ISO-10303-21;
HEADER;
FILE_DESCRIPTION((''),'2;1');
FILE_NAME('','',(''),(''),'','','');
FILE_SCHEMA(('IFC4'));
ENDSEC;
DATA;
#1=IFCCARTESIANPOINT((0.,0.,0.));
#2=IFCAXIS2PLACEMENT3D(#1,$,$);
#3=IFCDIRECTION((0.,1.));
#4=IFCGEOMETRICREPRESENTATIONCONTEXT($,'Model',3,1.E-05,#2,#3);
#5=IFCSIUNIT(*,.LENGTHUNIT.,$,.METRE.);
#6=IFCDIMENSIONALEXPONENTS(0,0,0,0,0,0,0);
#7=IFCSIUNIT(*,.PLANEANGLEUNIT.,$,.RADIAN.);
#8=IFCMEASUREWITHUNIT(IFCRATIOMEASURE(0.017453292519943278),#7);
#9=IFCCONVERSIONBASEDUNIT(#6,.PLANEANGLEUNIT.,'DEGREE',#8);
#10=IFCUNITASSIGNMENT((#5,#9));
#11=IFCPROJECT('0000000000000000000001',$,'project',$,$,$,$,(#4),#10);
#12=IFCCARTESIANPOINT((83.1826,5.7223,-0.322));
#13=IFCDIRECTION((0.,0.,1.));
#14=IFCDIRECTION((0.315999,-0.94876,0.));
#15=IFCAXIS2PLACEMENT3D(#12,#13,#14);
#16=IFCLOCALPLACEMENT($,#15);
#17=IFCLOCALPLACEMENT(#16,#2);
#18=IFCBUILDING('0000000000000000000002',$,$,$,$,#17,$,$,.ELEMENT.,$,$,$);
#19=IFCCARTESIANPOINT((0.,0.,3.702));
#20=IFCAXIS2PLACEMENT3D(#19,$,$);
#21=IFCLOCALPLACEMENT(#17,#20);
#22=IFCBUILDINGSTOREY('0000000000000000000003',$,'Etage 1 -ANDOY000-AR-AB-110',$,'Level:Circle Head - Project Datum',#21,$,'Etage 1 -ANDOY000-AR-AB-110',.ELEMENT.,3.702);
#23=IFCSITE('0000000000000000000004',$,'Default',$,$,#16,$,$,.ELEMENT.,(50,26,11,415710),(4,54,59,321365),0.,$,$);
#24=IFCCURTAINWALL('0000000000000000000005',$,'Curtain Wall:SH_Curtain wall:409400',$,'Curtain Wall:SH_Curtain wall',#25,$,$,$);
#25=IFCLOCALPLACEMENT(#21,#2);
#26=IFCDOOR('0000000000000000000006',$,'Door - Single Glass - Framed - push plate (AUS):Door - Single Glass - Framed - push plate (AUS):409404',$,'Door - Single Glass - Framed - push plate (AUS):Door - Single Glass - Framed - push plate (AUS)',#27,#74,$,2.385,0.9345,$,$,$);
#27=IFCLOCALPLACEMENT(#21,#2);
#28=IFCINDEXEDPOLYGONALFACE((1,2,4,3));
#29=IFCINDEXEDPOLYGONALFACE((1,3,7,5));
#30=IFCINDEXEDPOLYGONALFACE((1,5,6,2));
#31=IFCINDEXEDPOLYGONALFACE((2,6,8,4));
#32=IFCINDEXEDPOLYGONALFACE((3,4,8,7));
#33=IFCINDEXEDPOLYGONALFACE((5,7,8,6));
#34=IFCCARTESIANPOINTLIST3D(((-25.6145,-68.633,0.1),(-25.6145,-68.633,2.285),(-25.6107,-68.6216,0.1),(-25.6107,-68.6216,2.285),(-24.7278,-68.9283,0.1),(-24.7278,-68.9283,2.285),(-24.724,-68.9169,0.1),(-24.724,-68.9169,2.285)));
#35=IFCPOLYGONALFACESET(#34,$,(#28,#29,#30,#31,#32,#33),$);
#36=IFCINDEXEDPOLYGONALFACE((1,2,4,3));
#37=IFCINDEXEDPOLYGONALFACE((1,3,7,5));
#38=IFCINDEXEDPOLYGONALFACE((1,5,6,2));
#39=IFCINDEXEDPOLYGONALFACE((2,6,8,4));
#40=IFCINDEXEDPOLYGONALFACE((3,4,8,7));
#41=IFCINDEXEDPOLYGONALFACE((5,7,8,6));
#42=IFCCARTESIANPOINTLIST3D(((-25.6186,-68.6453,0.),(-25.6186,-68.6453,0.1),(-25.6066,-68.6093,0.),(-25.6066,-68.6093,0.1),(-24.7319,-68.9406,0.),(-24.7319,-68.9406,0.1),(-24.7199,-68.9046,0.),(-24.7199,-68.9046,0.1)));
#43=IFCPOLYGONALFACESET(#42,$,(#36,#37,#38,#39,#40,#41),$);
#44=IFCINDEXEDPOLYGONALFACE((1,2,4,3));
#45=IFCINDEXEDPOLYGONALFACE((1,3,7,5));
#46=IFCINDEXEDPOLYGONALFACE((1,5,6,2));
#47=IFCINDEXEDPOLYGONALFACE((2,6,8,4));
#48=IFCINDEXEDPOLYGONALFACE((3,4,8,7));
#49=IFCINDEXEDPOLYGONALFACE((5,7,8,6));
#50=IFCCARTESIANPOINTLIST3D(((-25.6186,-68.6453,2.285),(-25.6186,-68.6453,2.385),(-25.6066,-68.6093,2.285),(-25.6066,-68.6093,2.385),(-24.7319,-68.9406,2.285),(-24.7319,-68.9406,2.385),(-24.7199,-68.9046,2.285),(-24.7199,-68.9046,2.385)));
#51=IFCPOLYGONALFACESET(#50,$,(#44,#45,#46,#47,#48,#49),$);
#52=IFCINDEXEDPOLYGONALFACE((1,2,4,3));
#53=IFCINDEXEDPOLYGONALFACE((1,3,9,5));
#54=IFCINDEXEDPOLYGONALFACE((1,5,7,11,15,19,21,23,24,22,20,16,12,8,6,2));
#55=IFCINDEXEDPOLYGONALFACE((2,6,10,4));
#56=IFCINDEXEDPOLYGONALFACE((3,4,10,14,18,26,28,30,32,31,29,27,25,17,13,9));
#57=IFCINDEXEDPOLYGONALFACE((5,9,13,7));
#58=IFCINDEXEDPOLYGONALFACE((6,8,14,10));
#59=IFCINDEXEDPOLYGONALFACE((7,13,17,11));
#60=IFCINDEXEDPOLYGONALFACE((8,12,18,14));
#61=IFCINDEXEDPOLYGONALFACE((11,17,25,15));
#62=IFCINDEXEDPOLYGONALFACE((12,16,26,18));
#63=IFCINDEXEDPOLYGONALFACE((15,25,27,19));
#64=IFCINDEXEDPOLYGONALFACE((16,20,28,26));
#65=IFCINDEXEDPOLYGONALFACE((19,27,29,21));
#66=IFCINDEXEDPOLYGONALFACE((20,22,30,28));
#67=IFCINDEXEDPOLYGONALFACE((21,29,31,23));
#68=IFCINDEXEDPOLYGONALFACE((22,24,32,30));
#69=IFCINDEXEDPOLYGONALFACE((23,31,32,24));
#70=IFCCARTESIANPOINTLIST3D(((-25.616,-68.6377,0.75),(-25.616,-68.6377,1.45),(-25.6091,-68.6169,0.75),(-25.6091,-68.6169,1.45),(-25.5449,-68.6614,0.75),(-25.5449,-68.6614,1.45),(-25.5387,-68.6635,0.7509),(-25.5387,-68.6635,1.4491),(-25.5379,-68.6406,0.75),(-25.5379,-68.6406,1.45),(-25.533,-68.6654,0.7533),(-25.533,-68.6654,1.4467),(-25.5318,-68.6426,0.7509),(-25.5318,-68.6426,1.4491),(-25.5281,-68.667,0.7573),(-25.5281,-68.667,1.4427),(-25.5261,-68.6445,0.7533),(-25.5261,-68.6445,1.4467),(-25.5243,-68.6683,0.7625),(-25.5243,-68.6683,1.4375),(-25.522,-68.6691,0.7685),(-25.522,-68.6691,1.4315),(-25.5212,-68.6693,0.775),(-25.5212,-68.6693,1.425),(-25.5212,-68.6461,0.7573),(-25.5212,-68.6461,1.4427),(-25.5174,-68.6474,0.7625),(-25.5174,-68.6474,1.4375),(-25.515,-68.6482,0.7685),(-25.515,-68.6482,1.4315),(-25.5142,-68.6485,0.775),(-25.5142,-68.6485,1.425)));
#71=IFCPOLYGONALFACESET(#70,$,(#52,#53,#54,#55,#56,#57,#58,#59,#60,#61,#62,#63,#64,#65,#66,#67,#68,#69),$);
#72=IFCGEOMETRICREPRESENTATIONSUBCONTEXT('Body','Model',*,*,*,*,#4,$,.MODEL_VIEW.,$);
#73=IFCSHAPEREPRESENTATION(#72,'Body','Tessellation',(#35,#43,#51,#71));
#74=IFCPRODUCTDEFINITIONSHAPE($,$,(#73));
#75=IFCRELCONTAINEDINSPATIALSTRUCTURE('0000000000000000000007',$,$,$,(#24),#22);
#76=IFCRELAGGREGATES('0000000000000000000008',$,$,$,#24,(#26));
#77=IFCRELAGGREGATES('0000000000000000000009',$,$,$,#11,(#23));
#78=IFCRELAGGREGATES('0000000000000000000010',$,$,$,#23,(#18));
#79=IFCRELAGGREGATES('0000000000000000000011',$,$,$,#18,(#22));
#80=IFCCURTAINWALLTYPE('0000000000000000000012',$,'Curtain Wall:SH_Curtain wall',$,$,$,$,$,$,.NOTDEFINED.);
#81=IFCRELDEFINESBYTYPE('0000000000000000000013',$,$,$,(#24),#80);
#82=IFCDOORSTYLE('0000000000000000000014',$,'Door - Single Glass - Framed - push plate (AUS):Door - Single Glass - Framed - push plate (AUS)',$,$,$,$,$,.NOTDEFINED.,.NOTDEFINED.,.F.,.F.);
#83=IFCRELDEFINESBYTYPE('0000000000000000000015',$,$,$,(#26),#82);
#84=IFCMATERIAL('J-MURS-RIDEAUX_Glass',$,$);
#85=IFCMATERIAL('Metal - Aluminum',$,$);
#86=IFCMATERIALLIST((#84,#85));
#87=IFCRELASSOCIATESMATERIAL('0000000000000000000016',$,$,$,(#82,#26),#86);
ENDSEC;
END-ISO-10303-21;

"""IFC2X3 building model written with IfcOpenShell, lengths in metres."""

from ifc_helpers import new_model, entity, si_unit, converted_unit, direction, frame, frame_2d, origin, origin_2d_with_axis, place, context, subcontext, project, spatial, polyline, circle_curve, parameter, trimmed, segment, composite_curve, rectangle, outline, extrude, source, transform, mapped, material, material_list, type_object, type_shapes, element, aggregate, save


model = new_model("IFC2X3")

# Units and contexts
model_context = context("Model", 3, precision=1e-05, world=origin(), true_north=direction((0.0, 1.0)))
body_context = subcontext(model_context, "Body", "Model", "MODEL_VIEW")
ifc_project = project(units=[si_unit("LENGTHUNIT", "METRE"), converted_unit("PLANEANGLEUNIT", "DEGREE", entity("IfcRatioMeasure", 0.017453292519943278), si_unit("PLANEANGLEUNIT", "RADIAN"), dimensions=[0, 0, 0, 0, 0, 0, 0])], contexts=[model_context])

# Site, building, storey
site_placement = place(None, frame((83.1826, 5.7223, -0.322), z_axis=(0.0, 0.0, 1.0), x_axis=(0.315999, -0.94876, 0.0)))
site = spatial("IfcSite", under=ifc_project, at=site_placement, Name="Default", CompositionType="ELEMENT", RefLatitude=(50, 26, 11, 415710), RefLongitude=(4, 54, 59, 321365), RefElevation=0.0)
building_placement = place(site_placement, origin())
building = spatial("IfcBuilding", under=site, at=building_placement, CompositionType="ELEMENT")
storey_placement = place(building_placement, frame((0.0, 0.0, 3.702)))
storey = spatial("IfcBuildingStorey", under=building, at=storey_placement, Name="Etage 1 -ANDOY000-AR-AB-110", ObjectType="Level:Circle Head - Project Datum", LongName="Etage 1 -ANDOY000-AR-AB-110", CompositionType="ELEMENT", Elevation=3.702)

# Curtain wall
curtain_wall_type_1 = type_object("IfcCurtainWallType", Name="Curtain Wall:SH_Curtain wall", PredefinedType="NOTDEFINED")
curtain_wall_1_placement = place(storey_placement, frame((0.0, 0.0, -3.702)))
curtain_wall_1 = element("IfcCurtainWall", 1, at=curtain_wall_1_placement, inside=storey, type_object=curtain_wall_type_1, Name="Curtain Wall:SH_Curtain wall:409400", ObjectType="Curtain Wall:SH_Curtain wall")

# Shared definitions
ifc_material_1 = material(Name="J-MURS-RIDEAUX_Glass")

# Door
ifc_material_2 = material(Name="Metal - Aluminum")
ifc_material_list = material_list([ifc_material_1, ifc_material_2])
door_style_1 = type_object("IfcDoorStyle", Name="Door - Single Glass - Framed - push plate (AUS):Door - Single Glass - Framed - push plate (AUS)", ConstructionType="NOTDEFINED", OperationType="NOTDEFINED", ParameterTakesPrecedence=False, Sizeable=False, material=ifc_material_list)
shared_shape_1 = source(origin(), body_context, "Body", "SweptSolid", [
    extrude(rectangle(XDim=0.9345, YDim=0.012, at=frame_2d((0.0, 0.0), x_axis=(1.0, 0.0))), frame((0.0, 0.014, 0.1), z_axis=(0.0, 0.0, 1.0), x_axis=(-1.0, 0.0, 0.0)), (0.0, 0.0, 1.0), 2.185),
    extrude(rectangle(XDim=0.038, YDim=0.9345, at=origin_2d_with_axis()), frame((0.0, 0.014, 0.0), z_axis=(0.0, 0.0, 1.0), x_axis=(0.0, 1.0, 0.0)), (0.0, 0.0, 1.0), 0.1),
    extrude(rectangle(XDim=0.038, YDim=0.9345, at=frame_2d((0.0, 0.0), x_axis=(1.0, 0.0))), frame((0.0, 0.014, 2.285), z_axis=(0.0, 0.0, 1.0), x_axis=(0.0, 1.0, 0.0)), (0.0, 0.0, 1.0), 0.1),
    extrude(outline(composite_curve([segment(trimmed(circle_curve(frame_2d((0.0167, -0.325), x_axis=(1.0, 0.0)), 0.025), [parameter(270.0)], [parameter(0.0)], True, "PARAMETER"), True, "CONTINUOUS"), segment(polyline([(0.0417, -0.325), (0.0417, 0.325)]), True, "CONTINUOUS"), segment(trimmed(circle_curve(frame_2d((0.0167, 0.325), x_axis=(1.0, 0.0)), 0.025), [parameter(0.0)], [parameter(90.0)], True, "PARAMETER"), True, "CONTINUOUS"), segment(polyline([(0.0167, 0.35), (-0.0583, 0.35)]), True, "CONTINUOUS"), segment(polyline([(-0.0583, 0.35), (-0.0583, -0.35)]), True, "CONTINUOUS"), segment(polyline([(-0.0583, -0.35), (0.0167, -0.35)]), True, "CONTINUOUS")], self_intersect=False)), frame((-0.4089, 0.003, 1.1), z_axis=(0.0, 1.0, 0.0), x_axis=(1.0, 0.0, 0.0)), (0.0, 0.0, 1.0), 0.022),
])
type_shapes(door_style_1, [shared_shape_1])
door_1_placement = place(curtain_wall_1_placement, frame((-25.1737, -68.7882, 3.702), z_axis=(0.0, 0.0, 1.0), x_axis=(0.948759, -0.316, 0.0)))
door_1 = element("IfcDoor", 2, at=door_1_placement, type_object=door_style_1, material=ifc_material_list, Name="Door - Single Glass - Framed - push plate (AUS):Door - Single Glass - Framed - push plate (AUS):409404", ObjectType="Door - Single Glass - Framed - push plate (AUS):Door - Single Glass - Framed - push plate (AUS)", OverallHeight=2.385, OverallWidth=0.9345, context=body_context, shape_type="MappedRepresentation", body=[
    mapped(shared_shape_1, transform((0.0, 0.0, 0.0), scale=1.0)),
])
aggregate(curtain_wall_1, [door_1])

save(model, "model.ifc")
